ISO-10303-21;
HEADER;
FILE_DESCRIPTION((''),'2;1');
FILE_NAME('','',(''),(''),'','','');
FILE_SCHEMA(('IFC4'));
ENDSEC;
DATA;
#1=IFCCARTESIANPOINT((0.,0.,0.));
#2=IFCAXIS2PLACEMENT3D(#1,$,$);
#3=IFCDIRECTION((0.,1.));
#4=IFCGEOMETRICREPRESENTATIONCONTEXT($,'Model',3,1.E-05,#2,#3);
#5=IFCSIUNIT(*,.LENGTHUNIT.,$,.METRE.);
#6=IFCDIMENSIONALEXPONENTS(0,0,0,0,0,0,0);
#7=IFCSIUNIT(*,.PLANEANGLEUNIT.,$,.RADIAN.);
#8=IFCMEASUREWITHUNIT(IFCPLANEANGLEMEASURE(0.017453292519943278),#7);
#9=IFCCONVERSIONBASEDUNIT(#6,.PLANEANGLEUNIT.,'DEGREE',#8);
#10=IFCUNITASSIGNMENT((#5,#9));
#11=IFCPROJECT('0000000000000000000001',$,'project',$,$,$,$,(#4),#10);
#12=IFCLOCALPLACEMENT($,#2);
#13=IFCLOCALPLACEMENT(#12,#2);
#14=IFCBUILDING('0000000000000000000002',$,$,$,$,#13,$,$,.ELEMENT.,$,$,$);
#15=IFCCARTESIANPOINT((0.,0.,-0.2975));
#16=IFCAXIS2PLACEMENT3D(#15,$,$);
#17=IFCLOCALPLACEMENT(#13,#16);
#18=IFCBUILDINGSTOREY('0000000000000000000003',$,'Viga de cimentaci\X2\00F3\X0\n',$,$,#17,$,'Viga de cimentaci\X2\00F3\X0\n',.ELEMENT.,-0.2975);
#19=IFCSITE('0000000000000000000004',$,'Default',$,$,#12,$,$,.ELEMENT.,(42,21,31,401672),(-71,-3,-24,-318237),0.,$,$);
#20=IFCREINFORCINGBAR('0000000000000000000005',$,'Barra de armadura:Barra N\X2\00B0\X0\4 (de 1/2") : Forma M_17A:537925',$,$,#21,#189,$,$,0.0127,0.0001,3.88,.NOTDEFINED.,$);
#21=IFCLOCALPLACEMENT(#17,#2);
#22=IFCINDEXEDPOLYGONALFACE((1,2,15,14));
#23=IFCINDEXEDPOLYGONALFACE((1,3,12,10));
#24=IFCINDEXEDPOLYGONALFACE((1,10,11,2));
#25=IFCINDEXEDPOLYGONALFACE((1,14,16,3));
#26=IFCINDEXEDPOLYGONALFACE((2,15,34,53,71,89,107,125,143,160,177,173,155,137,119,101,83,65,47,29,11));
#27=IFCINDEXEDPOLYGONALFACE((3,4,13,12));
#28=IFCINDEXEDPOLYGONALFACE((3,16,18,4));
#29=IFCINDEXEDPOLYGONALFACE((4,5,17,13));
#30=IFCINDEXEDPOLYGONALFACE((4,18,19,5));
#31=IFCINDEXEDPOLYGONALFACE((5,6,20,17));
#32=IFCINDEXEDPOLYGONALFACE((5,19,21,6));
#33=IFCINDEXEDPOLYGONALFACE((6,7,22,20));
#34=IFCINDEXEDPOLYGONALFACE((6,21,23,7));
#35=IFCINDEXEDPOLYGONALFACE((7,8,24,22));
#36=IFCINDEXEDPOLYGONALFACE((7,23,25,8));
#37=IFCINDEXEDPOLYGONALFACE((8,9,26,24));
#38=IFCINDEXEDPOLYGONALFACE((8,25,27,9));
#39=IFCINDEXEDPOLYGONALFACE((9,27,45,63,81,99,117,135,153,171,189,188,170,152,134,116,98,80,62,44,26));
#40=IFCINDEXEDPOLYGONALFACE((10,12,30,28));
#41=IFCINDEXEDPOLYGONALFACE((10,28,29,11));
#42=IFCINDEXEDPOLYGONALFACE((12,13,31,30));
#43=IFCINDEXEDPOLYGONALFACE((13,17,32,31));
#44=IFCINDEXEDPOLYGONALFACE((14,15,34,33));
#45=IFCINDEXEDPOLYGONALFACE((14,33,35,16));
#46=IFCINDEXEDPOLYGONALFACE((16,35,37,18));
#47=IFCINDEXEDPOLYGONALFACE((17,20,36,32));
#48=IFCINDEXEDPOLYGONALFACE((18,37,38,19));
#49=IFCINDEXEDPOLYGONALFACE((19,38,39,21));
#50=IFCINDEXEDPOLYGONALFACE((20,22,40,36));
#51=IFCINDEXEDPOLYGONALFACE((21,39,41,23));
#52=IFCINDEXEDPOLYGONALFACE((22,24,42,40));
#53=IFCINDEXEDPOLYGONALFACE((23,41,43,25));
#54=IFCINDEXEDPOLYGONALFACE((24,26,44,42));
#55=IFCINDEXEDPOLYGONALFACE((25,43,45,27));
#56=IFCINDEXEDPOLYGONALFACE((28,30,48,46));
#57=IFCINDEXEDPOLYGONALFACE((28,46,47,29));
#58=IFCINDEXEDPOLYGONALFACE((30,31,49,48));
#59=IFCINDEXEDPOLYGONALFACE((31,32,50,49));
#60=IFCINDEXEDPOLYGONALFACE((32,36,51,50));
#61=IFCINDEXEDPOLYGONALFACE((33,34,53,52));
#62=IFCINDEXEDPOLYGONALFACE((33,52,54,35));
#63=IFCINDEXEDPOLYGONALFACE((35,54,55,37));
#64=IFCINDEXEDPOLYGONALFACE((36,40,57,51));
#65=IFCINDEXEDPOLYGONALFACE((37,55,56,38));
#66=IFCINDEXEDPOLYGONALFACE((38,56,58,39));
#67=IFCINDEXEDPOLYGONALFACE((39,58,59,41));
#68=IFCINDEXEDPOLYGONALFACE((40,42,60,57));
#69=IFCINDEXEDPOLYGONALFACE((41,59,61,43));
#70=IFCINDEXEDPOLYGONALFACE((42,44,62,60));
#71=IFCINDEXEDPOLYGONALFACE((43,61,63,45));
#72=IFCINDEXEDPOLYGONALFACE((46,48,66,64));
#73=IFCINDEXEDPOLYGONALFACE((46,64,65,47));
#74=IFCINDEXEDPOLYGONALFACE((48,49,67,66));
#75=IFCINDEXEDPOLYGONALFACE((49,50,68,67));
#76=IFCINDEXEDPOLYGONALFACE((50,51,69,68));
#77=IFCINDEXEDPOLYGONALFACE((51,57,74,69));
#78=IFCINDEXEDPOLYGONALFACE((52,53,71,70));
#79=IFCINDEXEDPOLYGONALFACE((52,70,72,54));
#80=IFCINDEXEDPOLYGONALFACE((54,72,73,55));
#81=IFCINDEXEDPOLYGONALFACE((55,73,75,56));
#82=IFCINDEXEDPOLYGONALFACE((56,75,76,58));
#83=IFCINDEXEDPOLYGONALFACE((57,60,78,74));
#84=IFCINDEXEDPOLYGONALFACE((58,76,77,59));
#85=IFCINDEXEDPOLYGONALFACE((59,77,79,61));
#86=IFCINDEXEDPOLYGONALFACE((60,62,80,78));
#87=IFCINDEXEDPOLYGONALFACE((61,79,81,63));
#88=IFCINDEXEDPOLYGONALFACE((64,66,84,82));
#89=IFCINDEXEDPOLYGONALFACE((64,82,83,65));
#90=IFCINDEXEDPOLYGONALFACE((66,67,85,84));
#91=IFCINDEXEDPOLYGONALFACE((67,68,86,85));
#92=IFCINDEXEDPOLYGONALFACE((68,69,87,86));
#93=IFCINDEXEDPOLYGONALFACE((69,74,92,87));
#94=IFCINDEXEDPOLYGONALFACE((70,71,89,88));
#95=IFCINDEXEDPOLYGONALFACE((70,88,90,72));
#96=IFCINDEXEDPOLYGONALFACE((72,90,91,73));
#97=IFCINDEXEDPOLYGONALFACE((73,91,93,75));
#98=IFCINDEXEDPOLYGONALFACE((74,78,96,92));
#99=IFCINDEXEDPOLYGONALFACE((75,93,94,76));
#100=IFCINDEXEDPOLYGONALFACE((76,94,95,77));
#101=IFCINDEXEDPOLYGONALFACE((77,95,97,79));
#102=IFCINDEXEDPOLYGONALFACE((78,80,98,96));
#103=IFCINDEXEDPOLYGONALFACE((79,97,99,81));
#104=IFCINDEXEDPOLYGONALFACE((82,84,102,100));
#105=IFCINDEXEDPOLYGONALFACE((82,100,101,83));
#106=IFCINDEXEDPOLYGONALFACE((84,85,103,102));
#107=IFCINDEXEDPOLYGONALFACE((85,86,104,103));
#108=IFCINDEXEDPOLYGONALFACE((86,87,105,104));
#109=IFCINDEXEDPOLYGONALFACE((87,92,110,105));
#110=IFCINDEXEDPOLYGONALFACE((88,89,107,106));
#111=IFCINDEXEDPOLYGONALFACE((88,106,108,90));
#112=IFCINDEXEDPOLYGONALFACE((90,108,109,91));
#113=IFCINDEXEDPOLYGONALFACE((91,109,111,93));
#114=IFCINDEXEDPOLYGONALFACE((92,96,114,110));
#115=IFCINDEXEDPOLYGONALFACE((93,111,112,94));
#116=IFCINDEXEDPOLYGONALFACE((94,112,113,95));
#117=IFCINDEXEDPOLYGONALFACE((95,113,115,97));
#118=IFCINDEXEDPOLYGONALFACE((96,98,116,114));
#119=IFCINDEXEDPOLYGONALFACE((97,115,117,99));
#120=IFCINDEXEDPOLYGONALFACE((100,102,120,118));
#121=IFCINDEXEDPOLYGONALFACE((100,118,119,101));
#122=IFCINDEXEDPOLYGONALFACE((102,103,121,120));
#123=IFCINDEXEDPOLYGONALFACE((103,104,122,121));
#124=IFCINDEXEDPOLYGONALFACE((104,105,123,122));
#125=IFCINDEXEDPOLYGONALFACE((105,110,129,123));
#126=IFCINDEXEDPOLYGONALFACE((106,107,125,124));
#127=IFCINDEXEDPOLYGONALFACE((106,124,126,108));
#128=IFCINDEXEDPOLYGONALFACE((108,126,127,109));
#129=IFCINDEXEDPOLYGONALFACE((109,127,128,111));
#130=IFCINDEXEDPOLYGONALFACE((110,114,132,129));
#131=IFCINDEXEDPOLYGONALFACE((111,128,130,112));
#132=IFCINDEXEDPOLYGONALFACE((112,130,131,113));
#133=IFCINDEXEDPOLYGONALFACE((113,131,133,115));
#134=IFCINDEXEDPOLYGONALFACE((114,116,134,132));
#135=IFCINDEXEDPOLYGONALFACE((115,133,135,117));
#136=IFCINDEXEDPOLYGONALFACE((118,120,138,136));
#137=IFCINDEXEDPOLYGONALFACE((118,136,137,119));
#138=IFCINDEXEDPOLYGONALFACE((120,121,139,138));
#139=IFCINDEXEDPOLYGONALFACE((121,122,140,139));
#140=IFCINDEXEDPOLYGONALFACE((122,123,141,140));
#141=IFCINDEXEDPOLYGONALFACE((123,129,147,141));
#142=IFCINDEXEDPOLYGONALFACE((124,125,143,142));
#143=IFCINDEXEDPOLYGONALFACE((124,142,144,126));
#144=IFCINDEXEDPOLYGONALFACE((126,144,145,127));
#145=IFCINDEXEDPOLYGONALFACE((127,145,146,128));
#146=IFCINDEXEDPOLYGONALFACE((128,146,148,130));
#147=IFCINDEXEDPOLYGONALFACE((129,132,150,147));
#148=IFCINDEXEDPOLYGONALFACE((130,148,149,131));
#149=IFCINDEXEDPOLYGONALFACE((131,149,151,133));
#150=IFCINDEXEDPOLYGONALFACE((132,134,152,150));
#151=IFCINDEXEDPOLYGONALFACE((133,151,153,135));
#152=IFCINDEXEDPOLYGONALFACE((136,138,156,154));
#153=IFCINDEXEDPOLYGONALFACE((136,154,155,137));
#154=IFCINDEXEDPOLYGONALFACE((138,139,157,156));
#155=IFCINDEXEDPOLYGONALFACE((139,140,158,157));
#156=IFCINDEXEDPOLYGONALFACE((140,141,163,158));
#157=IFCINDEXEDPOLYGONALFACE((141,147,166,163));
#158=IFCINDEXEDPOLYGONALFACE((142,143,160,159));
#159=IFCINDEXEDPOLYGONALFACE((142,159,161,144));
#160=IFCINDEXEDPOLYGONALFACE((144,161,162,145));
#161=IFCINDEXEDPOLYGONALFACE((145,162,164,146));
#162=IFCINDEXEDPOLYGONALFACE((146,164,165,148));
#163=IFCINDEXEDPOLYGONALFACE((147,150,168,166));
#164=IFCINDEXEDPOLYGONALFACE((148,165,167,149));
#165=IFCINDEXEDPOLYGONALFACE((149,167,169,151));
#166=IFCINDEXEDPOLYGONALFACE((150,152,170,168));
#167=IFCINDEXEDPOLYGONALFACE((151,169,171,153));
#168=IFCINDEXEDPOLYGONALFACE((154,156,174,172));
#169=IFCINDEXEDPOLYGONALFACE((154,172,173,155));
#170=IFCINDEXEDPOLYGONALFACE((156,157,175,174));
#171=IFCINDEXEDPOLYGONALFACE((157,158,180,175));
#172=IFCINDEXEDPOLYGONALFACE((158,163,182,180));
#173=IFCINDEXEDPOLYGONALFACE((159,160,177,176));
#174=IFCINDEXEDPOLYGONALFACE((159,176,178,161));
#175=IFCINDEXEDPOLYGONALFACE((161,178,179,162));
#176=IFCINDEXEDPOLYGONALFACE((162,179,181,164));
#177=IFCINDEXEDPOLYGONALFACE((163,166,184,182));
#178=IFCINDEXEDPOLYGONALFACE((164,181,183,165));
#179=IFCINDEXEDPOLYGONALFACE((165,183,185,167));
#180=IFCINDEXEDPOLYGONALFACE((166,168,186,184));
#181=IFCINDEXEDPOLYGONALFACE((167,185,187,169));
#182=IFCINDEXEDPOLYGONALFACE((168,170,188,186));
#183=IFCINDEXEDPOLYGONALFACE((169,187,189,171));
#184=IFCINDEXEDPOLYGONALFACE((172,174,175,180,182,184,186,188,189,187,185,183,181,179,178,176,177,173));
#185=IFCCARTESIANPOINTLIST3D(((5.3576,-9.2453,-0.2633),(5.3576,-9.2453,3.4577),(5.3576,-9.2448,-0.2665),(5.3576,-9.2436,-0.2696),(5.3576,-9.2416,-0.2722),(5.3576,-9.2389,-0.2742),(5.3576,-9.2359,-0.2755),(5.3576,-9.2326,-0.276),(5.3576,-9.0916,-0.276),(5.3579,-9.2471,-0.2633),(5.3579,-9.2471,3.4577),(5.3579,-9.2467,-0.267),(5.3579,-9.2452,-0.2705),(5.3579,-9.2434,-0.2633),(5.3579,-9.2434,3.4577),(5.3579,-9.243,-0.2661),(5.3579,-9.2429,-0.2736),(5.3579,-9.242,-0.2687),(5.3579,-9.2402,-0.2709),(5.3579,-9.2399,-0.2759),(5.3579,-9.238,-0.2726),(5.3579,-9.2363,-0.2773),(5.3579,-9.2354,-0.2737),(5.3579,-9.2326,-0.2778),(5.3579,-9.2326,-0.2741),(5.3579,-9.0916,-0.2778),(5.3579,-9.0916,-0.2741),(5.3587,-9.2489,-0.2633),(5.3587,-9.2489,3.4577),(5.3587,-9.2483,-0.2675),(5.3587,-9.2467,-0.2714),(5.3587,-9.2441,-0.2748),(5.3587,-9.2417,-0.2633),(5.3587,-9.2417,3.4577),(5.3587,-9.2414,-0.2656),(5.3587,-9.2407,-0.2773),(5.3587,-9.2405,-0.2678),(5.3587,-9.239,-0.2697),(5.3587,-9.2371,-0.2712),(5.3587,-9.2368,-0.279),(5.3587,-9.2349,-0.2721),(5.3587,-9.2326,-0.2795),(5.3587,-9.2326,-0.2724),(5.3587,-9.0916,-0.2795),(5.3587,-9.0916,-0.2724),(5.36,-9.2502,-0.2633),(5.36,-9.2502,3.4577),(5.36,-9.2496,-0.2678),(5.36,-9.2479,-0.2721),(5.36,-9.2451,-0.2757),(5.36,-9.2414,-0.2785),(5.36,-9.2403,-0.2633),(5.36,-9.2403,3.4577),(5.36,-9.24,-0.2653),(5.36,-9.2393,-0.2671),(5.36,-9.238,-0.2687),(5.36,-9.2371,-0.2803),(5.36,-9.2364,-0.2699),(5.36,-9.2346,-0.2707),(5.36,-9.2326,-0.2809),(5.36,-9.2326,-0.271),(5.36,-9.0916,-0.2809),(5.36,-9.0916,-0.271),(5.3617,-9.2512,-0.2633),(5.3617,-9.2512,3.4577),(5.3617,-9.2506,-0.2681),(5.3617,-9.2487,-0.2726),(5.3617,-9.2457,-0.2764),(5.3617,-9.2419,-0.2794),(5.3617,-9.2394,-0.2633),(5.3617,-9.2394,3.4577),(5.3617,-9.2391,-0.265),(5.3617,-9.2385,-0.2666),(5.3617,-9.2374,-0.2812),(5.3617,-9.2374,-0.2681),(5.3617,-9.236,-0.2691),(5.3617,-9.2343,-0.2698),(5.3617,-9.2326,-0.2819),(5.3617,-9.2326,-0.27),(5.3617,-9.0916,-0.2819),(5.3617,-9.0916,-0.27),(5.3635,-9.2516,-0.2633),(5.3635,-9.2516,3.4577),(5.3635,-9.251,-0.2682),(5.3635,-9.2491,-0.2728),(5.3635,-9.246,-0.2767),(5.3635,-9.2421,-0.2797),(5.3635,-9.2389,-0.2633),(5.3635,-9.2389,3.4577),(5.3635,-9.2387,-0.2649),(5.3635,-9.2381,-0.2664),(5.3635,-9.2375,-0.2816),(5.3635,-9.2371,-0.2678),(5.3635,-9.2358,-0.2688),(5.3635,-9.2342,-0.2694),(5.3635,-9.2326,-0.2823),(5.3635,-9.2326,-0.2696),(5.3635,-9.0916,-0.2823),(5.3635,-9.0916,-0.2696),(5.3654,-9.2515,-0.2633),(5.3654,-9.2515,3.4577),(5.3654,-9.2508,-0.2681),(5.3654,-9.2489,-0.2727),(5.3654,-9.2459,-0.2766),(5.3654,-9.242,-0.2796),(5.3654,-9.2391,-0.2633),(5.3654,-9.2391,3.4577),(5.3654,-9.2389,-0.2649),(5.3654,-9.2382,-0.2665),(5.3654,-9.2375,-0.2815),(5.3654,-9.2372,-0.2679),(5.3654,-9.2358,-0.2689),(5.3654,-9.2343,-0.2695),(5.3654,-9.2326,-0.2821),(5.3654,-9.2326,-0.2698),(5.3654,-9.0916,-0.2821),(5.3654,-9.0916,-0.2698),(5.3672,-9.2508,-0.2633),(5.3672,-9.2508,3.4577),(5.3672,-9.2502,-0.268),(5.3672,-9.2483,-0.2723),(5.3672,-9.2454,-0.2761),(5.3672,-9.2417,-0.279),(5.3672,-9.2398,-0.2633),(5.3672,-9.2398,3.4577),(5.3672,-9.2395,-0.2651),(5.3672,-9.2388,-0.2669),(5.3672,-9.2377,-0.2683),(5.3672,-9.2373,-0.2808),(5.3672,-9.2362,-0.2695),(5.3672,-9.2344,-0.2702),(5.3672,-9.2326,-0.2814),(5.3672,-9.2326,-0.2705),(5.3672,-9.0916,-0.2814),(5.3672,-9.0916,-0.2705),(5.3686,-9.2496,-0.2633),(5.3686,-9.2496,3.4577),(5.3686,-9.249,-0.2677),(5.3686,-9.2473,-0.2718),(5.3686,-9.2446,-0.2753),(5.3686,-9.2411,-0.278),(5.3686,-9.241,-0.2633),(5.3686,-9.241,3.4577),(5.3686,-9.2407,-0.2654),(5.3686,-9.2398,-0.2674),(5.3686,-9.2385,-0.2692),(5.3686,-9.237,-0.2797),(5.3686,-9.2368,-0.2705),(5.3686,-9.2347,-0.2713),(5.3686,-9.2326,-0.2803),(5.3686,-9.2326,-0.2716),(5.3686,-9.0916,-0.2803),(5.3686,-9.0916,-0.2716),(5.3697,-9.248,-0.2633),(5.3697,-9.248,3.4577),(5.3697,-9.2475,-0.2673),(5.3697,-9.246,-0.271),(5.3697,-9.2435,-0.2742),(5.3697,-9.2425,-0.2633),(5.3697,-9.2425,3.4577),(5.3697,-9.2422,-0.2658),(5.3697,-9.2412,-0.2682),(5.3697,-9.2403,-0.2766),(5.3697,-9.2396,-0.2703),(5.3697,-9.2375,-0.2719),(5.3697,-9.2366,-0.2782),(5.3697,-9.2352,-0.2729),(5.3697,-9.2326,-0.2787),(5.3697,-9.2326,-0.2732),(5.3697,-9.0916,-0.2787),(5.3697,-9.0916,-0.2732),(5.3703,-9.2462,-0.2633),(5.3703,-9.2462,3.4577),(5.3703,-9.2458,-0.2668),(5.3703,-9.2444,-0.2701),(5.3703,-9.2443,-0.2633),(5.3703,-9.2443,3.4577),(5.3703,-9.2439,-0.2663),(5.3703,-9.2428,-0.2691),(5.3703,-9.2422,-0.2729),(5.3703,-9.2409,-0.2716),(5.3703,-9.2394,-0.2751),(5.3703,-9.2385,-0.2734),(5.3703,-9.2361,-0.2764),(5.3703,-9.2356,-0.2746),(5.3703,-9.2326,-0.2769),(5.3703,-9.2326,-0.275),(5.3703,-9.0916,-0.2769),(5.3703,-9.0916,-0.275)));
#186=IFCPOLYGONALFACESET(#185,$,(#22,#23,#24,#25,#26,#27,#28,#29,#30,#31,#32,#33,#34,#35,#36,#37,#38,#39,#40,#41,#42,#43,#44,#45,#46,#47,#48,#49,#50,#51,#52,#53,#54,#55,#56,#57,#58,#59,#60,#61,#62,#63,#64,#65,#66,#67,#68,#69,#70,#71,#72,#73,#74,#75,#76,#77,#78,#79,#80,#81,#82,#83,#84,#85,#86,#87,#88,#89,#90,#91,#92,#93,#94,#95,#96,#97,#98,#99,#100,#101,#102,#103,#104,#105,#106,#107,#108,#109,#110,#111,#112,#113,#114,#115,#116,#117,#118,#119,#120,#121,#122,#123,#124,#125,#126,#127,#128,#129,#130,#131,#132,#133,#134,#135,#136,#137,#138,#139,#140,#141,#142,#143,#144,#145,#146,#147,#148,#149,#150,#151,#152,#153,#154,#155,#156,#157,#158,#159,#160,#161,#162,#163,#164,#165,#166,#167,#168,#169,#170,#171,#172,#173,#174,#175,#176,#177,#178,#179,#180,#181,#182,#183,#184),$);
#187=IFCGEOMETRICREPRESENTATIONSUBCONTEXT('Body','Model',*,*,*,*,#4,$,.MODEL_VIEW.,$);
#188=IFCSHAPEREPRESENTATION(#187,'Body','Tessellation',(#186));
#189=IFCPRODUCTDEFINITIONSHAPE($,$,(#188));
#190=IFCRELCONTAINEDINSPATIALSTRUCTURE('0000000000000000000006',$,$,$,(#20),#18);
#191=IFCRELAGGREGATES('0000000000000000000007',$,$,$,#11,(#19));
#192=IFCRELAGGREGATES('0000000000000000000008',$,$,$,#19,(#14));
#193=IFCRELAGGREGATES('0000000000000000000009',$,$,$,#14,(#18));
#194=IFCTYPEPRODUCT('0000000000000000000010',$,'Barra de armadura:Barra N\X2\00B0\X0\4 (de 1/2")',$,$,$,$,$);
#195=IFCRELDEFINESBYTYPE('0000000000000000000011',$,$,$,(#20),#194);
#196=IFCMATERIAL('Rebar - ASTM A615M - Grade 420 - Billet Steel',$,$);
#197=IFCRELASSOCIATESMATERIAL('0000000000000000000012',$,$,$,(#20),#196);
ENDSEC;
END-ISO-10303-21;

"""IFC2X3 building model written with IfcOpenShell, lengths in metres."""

from ifc_helpers import new_model, entity, si_unit, converted_unit, direction, frame, origin, place, context, subcontext, project, spatial, material, type_object, element, save


model = new_model("IFC2X3")

# Units and contexts
model_context = context("Model", 3, precision=1e-05, world=origin(), true_north=direction((0.0, 1.0)))
body_context = subcontext(model_context, "Body", "Model", "MODEL_VIEW")
ifc_project = project(units=[si_unit("LENGTHUNIT", "METRE"), converted_unit("PLANEANGLEUNIT", "DEGREE", entity("IfcPlaneAngleMeasure", 0.017453292519943278), si_unit("PLANEANGLEUNIT", "RADIAN"), dimensions=[0, 0, 0, 0, 0, 0, 0])], contexts=[model_context])

# Site, building, storey
site_placement = place(None, origin())
site = spatial("IfcSite", under=ifc_project, at=site_placement, Name="Default", CompositionType="ELEMENT", RefLatitude=(42, 21, 31, 401672), RefLongitude=(-71, -3, -24, -318237), RefElevation=0.0)
building_placement = place(site_placement, origin())
building = spatial("IfcBuilding", under=site, at=building_placement, CompositionType="ELEMENT")
storey_placement = place(building_placement, frame((0.0, 0.0, -0.2975)))
storey = spatial("IfcBuildingStorey", under=building, at=storey_placement, Name="Viga de cimentación", LongName="Viga de cimentación", CompositionType="ELEMENT", Elevation=-0.2975)

# Reinforcing bar
ifc_material_1 = material(Name="Rebar - ASTM A615M - Grade 420 - Billet Steel")
type_product_1 = type_object("IfcTypeProduct", Name="Barra de armadura:Barra N°4 (de 1/2\")")
reinforcing_bar_1_placement = place(storey_placement, origin())
element("IfcReinforcingBar", 1, at=reinforcing_bar_1_placement, inside=storey, type_object=type_product_1, material=ifc_material_1, Name="Barra de armadura:Barra N°4 (de 1/2\") : Forma M_17A:537925", BarLength=3.88, BarRole="NOTDEFINED", CrossSectionArea=0.0001, NominalDiameter=0.0127, context=body_context, shape_type="AdvancedSweptSolid", body=[
    entity("IfcSweptDiskSolid", entity("IfcCompositeCurve", [entity("IfcCompositeCurveSegment", "CONTINUOUS", True, entity("IfcPolyline", [entity("IfcCartesianPoint", [5.364, -9.2453, 3.4577]), entity("IfcCartesianPoint", [5.364, -9.2453, -0.2633])])), entity("IfcCompositeCurveSegment", "CONTINUOUS", True, entity("IfcTrimmedCurve", entity("IfcCircle", entity("IfcAxis2Placement3D", entity("IfcCartesianPoint", [5.364, -9.2326, -0.2633]), entity("IfcDirection", [1.0, 0.0, 0.0]), entity("IfcDirection", [0.0, 0.0, -1.0])), 0.0127), [entity("IfcParameterValue", 270.0)], [entity("IfcParameterValue", 360.0)], True, "PARAMETER")), entity("IfcCompositeCurveSegment", "CONTINUOUS", True, entity("IfcPolyline", [entity("IfcCartesianPoint", [5.364, -9.2326, -0.276]), entity("IfcCartesianPoint", [5.364, -9.0916, -0.276])]))], False), 0.0063, None, 0.0, 92.0),
])

save(model, "model.ifc")
